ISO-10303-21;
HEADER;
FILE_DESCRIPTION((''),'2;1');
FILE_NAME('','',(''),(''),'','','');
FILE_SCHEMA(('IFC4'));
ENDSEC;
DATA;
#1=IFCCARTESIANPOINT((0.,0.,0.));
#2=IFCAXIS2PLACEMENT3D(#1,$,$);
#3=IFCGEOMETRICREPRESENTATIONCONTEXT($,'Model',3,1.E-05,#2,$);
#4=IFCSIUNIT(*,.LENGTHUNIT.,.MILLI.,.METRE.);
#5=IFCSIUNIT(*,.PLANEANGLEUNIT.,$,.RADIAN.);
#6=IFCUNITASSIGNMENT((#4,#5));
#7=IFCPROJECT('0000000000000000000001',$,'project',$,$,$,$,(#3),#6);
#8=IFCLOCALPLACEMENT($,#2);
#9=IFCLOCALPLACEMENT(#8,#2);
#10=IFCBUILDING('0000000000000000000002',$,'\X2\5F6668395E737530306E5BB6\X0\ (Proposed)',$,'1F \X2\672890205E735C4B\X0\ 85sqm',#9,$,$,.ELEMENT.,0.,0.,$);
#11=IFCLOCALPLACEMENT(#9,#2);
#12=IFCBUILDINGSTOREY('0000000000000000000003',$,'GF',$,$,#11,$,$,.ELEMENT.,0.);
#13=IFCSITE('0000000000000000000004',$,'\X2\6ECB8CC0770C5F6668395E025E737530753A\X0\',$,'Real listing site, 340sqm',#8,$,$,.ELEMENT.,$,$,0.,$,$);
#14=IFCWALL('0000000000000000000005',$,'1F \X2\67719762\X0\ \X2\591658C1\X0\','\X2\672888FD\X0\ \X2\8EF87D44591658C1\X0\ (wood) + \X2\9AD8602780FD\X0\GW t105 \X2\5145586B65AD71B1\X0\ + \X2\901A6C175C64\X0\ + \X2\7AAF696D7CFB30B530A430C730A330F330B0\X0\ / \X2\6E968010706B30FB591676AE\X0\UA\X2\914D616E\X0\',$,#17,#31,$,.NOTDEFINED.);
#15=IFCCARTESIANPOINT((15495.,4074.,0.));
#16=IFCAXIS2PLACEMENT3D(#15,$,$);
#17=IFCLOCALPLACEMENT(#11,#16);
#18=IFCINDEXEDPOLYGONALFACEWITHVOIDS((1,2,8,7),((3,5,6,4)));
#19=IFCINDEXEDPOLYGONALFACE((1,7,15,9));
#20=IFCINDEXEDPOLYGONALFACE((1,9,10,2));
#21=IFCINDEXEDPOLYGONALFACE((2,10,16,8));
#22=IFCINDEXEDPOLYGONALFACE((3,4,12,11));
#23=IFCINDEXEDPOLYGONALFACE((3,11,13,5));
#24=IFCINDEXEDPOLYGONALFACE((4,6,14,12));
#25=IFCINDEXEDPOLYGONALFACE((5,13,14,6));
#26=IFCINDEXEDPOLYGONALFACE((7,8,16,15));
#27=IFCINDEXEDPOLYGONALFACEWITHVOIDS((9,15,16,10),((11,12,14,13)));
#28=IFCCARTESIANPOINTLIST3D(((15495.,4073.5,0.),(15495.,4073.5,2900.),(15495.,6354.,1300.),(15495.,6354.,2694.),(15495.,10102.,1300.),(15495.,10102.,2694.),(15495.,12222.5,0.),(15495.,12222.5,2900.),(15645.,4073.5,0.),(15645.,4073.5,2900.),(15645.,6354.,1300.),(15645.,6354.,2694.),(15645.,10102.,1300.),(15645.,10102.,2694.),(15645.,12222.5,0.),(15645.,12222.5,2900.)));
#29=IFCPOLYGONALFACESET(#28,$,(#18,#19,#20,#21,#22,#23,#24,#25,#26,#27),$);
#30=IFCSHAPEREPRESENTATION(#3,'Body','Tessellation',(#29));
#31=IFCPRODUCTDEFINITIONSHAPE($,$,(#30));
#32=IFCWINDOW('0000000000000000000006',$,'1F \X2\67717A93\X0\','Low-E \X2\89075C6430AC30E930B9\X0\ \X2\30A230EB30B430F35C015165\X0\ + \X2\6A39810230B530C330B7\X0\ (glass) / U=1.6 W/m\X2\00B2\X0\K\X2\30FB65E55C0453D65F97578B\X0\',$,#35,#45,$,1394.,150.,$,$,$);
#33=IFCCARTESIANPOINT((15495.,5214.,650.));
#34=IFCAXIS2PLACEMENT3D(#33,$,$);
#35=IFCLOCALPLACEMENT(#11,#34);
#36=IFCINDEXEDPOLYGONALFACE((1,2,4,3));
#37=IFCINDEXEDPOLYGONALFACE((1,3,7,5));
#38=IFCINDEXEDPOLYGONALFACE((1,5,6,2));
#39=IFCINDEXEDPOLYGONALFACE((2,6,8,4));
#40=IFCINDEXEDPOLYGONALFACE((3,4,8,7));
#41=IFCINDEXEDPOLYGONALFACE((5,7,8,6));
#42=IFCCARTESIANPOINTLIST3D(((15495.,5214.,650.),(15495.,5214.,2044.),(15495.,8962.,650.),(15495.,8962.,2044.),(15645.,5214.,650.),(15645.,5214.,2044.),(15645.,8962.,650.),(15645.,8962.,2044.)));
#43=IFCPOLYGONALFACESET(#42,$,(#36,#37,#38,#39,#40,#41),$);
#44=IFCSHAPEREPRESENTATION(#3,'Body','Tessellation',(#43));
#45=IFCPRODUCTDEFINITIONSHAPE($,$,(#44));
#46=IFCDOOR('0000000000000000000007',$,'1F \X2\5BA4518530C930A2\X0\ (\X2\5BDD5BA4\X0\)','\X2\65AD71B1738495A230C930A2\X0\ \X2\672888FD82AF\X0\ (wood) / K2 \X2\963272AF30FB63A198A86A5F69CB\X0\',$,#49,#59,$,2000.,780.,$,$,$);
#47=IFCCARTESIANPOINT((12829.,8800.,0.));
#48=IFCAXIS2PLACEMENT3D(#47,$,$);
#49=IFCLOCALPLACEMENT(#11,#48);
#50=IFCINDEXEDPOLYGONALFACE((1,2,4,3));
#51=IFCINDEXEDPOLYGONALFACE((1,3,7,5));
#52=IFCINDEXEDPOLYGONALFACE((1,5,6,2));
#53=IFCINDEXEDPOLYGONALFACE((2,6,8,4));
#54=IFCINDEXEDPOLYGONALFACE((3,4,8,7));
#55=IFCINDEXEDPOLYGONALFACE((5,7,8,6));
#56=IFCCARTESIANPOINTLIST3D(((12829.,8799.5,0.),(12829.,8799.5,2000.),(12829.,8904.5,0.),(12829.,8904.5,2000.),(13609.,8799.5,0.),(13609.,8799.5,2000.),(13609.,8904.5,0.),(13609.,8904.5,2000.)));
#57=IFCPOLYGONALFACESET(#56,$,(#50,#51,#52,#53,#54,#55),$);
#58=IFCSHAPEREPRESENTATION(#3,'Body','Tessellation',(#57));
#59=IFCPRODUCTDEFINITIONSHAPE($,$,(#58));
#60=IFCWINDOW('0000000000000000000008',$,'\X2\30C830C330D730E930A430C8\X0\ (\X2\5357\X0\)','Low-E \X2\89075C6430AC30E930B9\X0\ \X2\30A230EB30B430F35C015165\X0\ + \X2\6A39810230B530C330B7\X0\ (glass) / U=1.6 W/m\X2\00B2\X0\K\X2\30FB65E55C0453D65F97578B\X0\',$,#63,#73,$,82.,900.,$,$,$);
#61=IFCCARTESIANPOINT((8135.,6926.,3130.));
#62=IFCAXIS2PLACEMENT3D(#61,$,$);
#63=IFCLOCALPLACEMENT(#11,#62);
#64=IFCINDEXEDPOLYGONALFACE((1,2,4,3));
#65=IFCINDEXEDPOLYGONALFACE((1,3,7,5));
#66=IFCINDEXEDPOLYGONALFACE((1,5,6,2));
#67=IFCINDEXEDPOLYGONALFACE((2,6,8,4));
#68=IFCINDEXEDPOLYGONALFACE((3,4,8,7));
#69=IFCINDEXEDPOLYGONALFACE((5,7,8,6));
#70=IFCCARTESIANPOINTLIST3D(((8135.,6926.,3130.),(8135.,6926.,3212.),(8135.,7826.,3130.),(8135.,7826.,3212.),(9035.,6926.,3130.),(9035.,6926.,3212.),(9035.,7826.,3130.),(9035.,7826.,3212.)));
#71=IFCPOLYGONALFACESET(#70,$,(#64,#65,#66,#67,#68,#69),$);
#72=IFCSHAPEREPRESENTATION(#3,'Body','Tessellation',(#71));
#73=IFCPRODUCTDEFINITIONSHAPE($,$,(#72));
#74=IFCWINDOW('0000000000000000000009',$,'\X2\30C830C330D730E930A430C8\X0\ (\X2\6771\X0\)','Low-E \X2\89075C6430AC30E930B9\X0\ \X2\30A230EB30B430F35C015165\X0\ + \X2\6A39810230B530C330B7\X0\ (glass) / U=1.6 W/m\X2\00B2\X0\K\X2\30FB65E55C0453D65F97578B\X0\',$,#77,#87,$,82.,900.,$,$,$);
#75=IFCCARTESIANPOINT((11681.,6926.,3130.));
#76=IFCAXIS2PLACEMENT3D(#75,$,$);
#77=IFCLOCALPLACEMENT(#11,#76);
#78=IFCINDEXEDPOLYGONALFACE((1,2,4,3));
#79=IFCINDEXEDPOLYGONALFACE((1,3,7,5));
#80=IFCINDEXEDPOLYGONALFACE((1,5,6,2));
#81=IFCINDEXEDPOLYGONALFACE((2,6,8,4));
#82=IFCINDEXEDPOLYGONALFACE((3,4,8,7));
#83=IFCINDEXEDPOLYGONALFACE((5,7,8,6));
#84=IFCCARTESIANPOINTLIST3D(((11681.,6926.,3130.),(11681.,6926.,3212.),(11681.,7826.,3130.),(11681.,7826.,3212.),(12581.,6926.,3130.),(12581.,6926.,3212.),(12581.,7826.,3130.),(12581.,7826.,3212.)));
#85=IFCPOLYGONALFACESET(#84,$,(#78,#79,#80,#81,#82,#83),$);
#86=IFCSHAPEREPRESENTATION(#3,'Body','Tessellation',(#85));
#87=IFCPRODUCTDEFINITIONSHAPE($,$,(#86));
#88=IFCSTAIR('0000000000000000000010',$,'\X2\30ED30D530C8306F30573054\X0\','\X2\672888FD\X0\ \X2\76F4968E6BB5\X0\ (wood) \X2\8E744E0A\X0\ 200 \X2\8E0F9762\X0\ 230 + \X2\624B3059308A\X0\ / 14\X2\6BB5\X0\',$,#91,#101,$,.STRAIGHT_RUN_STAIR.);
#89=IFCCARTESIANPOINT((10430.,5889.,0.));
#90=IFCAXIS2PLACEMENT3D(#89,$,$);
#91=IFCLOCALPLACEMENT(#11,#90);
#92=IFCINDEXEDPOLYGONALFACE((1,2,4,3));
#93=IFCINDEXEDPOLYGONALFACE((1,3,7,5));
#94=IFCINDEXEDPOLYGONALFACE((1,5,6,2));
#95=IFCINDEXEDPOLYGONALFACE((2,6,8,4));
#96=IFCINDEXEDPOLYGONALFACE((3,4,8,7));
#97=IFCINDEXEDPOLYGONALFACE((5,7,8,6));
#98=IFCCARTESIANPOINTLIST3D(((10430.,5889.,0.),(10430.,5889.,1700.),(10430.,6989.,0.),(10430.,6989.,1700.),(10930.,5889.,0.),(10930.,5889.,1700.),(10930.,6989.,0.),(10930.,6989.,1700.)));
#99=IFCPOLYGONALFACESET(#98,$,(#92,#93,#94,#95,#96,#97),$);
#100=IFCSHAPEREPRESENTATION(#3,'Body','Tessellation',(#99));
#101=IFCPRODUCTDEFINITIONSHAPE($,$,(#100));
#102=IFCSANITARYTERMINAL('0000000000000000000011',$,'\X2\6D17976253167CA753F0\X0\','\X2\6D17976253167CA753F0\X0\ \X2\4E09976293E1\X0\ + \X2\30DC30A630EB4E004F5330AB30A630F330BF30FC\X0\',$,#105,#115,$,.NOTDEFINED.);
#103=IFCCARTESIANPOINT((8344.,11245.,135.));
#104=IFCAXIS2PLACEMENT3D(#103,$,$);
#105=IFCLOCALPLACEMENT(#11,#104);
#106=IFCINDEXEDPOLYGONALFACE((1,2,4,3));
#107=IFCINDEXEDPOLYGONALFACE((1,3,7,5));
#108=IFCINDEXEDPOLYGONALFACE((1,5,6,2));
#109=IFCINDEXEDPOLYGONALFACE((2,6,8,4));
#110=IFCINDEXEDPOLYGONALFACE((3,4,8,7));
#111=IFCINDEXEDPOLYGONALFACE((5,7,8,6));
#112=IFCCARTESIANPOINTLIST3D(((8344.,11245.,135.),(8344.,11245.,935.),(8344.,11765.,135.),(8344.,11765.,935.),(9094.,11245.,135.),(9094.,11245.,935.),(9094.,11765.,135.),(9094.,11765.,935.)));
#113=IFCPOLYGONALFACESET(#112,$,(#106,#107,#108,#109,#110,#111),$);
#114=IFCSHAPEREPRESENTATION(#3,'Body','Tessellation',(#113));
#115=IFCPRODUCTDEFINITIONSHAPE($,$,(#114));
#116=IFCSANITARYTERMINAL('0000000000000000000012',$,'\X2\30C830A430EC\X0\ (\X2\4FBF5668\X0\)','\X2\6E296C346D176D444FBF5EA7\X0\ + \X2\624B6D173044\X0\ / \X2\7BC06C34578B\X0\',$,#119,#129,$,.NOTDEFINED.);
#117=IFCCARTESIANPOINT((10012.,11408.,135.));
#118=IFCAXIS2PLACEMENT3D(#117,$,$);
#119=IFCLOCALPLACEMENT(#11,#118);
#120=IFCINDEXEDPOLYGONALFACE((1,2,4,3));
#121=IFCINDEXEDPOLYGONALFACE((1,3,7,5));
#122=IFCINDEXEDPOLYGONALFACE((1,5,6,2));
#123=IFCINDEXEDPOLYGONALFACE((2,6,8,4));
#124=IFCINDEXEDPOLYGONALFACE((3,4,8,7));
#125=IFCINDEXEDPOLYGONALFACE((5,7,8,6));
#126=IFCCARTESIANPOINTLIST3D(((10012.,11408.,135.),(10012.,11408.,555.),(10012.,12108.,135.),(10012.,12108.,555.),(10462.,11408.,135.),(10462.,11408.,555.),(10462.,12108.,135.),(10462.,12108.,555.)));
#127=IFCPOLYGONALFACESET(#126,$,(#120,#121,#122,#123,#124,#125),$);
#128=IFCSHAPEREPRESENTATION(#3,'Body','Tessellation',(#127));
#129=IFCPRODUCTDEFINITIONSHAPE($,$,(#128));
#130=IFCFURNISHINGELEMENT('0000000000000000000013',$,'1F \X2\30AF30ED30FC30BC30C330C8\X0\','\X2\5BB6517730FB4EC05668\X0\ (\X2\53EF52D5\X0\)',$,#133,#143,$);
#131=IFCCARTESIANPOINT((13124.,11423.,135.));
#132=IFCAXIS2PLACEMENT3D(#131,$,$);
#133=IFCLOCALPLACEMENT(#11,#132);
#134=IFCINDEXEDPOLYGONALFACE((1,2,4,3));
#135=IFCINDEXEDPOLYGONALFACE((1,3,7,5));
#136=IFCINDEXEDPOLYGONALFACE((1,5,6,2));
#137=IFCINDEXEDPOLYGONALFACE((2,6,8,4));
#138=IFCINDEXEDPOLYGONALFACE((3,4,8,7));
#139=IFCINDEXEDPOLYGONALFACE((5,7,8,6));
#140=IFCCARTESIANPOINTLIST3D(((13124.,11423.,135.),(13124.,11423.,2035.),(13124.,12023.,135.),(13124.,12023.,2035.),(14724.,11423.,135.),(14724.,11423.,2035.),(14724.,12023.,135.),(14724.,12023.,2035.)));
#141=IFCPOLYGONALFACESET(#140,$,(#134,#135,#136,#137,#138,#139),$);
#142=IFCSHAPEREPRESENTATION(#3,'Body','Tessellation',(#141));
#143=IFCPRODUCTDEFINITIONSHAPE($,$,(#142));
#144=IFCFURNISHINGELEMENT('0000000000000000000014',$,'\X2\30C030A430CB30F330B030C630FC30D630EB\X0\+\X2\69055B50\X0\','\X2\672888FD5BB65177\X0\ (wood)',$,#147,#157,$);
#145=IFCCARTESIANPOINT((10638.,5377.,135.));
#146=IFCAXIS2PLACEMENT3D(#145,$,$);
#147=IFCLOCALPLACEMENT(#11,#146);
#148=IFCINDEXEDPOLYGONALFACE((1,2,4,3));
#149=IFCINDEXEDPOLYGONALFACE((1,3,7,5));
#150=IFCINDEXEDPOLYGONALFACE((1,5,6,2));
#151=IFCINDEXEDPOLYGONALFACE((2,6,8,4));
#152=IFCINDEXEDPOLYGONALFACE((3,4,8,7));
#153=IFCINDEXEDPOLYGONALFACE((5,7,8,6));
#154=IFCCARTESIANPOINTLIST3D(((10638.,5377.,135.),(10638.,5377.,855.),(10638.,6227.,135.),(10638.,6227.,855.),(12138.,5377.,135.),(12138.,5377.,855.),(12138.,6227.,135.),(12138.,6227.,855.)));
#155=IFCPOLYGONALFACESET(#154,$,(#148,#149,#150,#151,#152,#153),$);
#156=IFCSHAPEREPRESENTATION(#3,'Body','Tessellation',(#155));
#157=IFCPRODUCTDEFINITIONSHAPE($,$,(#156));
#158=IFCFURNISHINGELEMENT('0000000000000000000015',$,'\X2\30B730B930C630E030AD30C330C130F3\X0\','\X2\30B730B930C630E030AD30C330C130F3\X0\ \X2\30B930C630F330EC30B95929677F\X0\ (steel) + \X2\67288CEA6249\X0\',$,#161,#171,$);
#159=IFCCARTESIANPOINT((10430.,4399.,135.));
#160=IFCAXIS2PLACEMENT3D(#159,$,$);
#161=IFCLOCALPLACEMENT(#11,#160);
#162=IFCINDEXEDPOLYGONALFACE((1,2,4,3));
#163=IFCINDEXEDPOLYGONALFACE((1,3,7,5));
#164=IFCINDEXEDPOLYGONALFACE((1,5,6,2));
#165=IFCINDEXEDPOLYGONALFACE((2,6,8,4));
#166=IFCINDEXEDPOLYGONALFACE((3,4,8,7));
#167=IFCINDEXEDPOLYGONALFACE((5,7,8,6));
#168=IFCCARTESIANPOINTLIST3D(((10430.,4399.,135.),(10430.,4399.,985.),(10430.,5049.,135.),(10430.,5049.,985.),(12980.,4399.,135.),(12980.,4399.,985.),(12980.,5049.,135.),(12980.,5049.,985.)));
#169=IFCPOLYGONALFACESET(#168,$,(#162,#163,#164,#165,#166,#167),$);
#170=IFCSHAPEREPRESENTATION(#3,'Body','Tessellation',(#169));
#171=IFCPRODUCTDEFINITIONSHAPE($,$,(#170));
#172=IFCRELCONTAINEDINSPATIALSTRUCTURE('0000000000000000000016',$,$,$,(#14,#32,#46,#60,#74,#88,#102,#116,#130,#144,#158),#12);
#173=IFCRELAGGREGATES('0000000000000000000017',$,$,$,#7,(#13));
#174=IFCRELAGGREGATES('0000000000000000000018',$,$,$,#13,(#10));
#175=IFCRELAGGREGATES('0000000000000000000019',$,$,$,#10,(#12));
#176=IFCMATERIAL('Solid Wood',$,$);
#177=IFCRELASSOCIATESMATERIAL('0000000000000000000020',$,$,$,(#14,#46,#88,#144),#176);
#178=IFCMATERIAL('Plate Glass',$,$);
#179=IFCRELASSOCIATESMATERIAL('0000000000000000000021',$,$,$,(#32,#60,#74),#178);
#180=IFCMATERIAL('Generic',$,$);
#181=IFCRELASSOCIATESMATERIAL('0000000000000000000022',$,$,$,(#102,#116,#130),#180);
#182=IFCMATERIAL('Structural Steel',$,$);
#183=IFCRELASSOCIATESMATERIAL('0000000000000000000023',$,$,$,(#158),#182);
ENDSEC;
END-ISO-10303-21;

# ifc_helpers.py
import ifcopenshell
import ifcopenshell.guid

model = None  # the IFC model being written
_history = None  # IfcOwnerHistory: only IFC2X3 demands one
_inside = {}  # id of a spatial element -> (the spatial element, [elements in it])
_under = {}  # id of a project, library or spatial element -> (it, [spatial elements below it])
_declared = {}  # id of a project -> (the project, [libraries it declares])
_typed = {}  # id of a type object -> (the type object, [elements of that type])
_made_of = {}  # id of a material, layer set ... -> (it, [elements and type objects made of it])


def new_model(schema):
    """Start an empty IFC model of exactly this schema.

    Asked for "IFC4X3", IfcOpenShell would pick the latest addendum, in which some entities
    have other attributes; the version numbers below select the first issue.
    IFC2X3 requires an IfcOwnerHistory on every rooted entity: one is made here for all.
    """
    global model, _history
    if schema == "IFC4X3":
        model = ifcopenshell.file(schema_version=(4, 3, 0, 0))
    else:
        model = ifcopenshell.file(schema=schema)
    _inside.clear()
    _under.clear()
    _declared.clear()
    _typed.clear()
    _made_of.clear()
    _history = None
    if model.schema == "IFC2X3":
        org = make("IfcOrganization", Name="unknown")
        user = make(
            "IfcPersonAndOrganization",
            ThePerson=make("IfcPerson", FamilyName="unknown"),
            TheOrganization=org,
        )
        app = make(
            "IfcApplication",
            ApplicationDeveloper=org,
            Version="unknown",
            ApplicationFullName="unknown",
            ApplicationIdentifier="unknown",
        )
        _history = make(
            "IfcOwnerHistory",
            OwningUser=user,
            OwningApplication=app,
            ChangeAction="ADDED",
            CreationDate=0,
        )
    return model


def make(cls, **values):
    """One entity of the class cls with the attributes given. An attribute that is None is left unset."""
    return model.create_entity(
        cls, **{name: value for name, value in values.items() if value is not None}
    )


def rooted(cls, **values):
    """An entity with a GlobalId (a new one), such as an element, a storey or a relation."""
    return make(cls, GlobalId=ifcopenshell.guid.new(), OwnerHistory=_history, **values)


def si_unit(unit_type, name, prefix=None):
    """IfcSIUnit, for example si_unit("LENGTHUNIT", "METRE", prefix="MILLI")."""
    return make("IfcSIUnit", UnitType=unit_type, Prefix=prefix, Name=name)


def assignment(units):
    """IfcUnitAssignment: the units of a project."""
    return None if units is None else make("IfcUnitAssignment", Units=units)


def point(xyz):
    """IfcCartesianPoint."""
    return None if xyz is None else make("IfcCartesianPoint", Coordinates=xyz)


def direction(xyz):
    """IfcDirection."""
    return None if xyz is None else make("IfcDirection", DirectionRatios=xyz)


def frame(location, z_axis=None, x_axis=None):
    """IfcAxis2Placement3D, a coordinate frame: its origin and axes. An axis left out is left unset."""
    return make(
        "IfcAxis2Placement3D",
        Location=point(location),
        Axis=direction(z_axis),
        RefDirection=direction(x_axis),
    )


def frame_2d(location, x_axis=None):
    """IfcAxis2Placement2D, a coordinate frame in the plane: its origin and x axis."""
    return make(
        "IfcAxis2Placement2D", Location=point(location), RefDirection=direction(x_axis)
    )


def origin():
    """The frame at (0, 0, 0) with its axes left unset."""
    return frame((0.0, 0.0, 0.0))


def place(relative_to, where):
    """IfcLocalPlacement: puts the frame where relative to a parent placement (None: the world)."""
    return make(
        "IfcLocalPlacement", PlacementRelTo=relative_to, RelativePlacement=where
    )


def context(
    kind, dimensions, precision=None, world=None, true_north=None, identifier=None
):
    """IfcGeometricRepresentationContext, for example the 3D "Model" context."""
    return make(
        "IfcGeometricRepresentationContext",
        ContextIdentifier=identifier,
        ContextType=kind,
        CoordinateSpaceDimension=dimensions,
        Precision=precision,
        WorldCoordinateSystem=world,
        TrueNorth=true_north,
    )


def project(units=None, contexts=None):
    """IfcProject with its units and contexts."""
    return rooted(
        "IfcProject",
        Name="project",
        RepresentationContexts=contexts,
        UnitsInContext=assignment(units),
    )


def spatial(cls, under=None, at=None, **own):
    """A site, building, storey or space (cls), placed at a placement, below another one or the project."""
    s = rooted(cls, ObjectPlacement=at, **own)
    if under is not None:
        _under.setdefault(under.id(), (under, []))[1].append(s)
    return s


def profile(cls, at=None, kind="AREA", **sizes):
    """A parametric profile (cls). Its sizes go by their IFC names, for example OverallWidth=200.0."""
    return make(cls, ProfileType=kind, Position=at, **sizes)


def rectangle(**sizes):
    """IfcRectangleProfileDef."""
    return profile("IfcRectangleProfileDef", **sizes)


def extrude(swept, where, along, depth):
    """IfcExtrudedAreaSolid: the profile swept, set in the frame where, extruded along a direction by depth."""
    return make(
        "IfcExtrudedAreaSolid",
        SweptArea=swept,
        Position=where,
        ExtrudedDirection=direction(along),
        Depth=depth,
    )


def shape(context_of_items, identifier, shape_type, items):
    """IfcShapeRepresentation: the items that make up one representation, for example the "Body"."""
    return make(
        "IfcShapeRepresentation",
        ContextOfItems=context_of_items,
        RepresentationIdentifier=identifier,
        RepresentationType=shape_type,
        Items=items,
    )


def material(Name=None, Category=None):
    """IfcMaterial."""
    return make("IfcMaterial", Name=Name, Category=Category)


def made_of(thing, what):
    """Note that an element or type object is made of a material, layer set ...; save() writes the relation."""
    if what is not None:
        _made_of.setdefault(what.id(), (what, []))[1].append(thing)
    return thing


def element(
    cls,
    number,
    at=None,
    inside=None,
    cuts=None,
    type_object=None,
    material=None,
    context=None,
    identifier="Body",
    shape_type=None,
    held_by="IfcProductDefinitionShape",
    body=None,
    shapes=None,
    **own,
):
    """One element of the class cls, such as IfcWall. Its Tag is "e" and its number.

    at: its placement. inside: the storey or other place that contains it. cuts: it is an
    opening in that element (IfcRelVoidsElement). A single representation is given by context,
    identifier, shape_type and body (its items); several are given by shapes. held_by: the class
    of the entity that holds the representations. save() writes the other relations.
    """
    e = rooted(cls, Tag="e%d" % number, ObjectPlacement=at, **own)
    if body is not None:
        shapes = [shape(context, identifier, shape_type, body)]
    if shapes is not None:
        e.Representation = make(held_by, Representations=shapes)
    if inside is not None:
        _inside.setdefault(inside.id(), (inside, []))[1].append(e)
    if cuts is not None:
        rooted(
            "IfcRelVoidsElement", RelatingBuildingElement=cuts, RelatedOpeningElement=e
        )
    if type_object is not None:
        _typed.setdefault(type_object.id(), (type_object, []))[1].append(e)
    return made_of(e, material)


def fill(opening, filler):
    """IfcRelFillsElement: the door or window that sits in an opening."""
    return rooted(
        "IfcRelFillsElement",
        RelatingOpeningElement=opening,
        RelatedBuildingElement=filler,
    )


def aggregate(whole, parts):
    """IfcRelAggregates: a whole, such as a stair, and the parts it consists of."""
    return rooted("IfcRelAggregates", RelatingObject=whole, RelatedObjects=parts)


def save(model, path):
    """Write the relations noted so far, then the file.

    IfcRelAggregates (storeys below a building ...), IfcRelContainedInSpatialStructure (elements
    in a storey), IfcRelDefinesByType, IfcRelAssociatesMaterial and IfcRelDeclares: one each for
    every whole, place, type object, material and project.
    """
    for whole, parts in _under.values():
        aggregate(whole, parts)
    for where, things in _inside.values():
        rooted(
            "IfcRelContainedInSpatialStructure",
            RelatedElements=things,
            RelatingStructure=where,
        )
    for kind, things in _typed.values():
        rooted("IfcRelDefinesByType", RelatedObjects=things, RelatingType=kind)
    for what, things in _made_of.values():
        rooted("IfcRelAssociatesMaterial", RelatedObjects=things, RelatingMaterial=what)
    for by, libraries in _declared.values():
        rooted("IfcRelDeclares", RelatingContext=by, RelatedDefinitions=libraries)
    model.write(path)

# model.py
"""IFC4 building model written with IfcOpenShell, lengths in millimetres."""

from ifc_helpers import new_model, si_unit, frame, frame_2d, origin, place, context, project, spatial, rectangle, extrude, material, element, fill, save


model = new_model("IFC4")

# Units and contexts
model_context = context("Model", 3, precision=1e-05, world=origin())
ifc_project = project(units=[si_unit("LENGTHUNIT", "METRE", prefix="MILLI"), si_unit("PLANEANGLEUNIT", "RADIAN")], contexts=[model_context])

# Site, building, storey
site_placement = place(None, origin())
site = spatial("IfcSite", under=ifc_project, at=site_placement, Name="滋賀県彦根市平田町", ObjectType="Real listing site, 340sqm", CompositionType="ELEMENT", RefElevation=0.0)
building_placement = place(site_placement, origin())
building = spatial("IfcBuilding", under=site, at=building_placement, Name="彦根平田の家 (Proposed)", ObjectType="1F 木造平屋 85sqm", CompositionType="ELEMENT", ElevationOfRefHeight=0.0, ElevationOfTerrain=0.0)
storey_placement = place(building_placement, origin())
storey = spatial("IfcBuildingStorey", under=building, at=storey_placement, Name="GF", CompositionType="ELEMENT", Elevation=0.0)

# Wall, opening, window
ifc_material_1 = material(Name="Solid Wood")
wall_1_placement = place(storey_placement, frame((15495.0, 4074.0, 0.0)))
wall_1 = element("IfcWall", 1, at=wall_1_placement, inside=storey, material=ifc_material_1, Name="1F 東面 外壁", Description="木製 軸組外壁 (wood) + 高性能GW t105 充填断熱 + 通気層 + 窯業系サイディング / 準耐火・外皮UA配慮", PredefinedType="NOTDEFINED", context=model_context, shape_type="SweptSolid", body=[
    extrude(rectangle(XDim=150.0, YDim=8149.0, at=frame_2d((75.0, 4074.0))), frame((15495.0, 4074.0, 0.0)), (0.0, 0.0, 1.0), 2900.0),
])
opening_placement = place(storey_placement, frame((15495.0, 5214.0, 650.0)))
opening = element("IfcOpeningElement", 2, at=opening_placement, cuts=wall_1, PredefinedType="NOTDEFINED", context=model_context, shape_type="SweptSolid", body=[
    extrude(rectangle(XDim=150.0, YDim=3748.0, at=frame_2d((75.0, 1874.0))), frame((15495.0, 5214.0, 650.0)), (0.0, 0.0, 1.0), 1394.0),
])
ifc_material_2 = material(Name="Plate Glass")
window_1_placement = place(storey_placement, frame((15495.0, 5214.0, 650.0)))
window_1 = element("IfcWindow", 3, at=window_1_placement, inside=storey, material=ifc_material_2, Name="1F 東窓", Description="Low-E 複層ガラス アルゴン封入 + 樹脂サッシ (glass) / U=1.6 W/m²K・日射取得型", OverallHeight=1394.0, OverallWidth=150.0, context=model_context, shape_type="SweptSolid", body=[
    extrude(rectangle(XDim=150.0, YDim=3748.0, at=frame_2d((75.0, 1874.0))), frame((15495.0, 5214.0, 650.0)), (0.0, 0.0, 1.0), 1394.0),
])
fill(opening, window_1)

# Door
door_placement = place(storey_placement, frame((12829.0, 8800.0, 0.0)))
element("IfcDoor", 4, at=door_placement, inside=storey, material=ifc_material_1, Name="1F 室内ドア (寝室)", Description="断熱玄関ドア 木製芯 (wood) / K2 防犯・採風機構", OverallHeight=2000.0, OverallWidth=780.0, context=model_context, shape_type="SweptSolid", body=[
    extrude(rectangle(XDim=780.0, YDim=105.0, at=frame_2d((390.0, 52.0))), frame((12829.0, 8800.0, 0.0)), (0.0, 0.0, 1.0), 2000.0),
])

# Windows
window_2_placement = place(storey_placement, frame((8135.0, 6926.0, 3130.0)))
element("IfcWindow", 5, at=window_2_placement, inside=storey, material=ifc_material_2, Name="トップライト (南)", Description="Low-E 複層ガラス アルゴン封入 + 樹脂サッシ (glass) / U=1.6 W/m²K・日射取得型", OverallHeight=82.0, OverallWidth=900.0, context=model_context, shape_type="SweptSolid", body=[
    extrude(rectangle(XDim=900.0, YDim=900.0, at=frame_2d((450.0, 450.0))), frame((8135.0, 6926.0, 3130.0)), (0.0, 0.0, 1.0), 82.0),
])
window_3_placement = place(storey_placement, frame((11681.0, 6926.0, 3130.0)))
element("IfcWindow", 6, at=window_3_placement, inside=storey, material=ifc_material_2, Name="トップライト (東)", Description="Low-E 複層ガラス アルゴン封入 + 樹脂サッシ (glass) / U=1.6 W/m²K・日射取得型", OverallHeight=82.0, OverallWidth=900.0, context=model_context, shape_type="SweptSolid", body=[
    extrude(rectangle(XDim=900.0, YDim=900.0, at=frame_2d((450.0, 450.0))), frame((11681.0, 6926.0, 3130.0)), (0.0, 0.0, 1.0), 82.0),
])

# Stair
stair_placement = place(storey_placement, frame((10430.0, 5889.0, 0.0)))
element("IfcStair", 7, at=stair_placement, inside=storey, material=ifc_material_1, Name="ロフトはしご", Description="木製 直階段 (wood) 蹴上 200 踏面 230 + 手すり / 14段", PredefinedType="STRAIGHT_RUN_STAIR", context=model_context, shape_type="SweptSolid", body=[
    extrude(rectangle(XDim=500.0, YDim=1100.0, at=frame_2d((250.0, 550.0))), frame((10430.0, 5889.0, 0.0)), (0.0, 0.0, 1.0), 1700.0),
])

# Sanitary terminals
ifc_material_3 = material(Name="Generic")
sanitary_terminal_1_placement = place(storey_placement, frame((8344.0, 11245.0, 135.0)))
element("IfcSanitaryTerminal", 8, at=sanitary_terminal_1_placement, inside=storey, material=ifc_material_3, Name="洗面化粧台", Description="洗面化粧台 三面鏡 + ボウル一体カウンター", PredefinedType="NOTDEFINED", context=model_context, shape_type="SweptSolid", body=[
    extrude(rectangle(XDim=750.0, YDim=520.0, at=frame_2d((375.0, 260.0))), frame((8344.0, 11245.0, 135.0)), (0.0, 0.0, 1.0), 800.0),
])
sanitary_terminal_2_placement = place(storey_placement, frame((10012.0, 11408.0, 135.0)))
element("IfcSanitaryTerminal", 9, at=sanitary_terminal_2_placement, inside=storey, material=ifc_material_3, Name="トイレ (便器)", Description="温水洗浄便座 + 手洗い / 節水型", PredefinedType="NOTDEFINED", context=model_context, shape_type="SweptSolid", body=[
    extrude(rectangle(XDim=450.0, YDim=700.0, at=frame_2d((225.0, 350.0))), frame((10012.0, 11408.0, 135.0)), (0.0, 0.0, 1.0), 420.0),
])

# Furnishing elements
furnishing_1_placement = place(storey_placement, frame((13124.0, 11423.0, 135.0)))
element("IfcFurnishingElement", 10, at=furnishing_1_placement, inside=storey, material=ifc_material_3, Name="1F クローゼット", Description="家具・什器 (可動)", context=model_context, shape_type="SweptSolid", body=[
    extrude(rectangle(XDim=1600.0, YDim=600.0, at=frame_2d((800.0, 300.0))), frame((13124.0, 11423.0, 135.0)), (0.0, 0.0, 1.0), 1900.0),
])
furnishing_2_placement = place(storey_placement, frame((10638.0, 5377.0, 135.0)))
element("IfcFurnishingElement", 11, at=furnishing_2_placement, inside=storey, material=ifc_material_1, Name="ダイニングテーブル+椅子", Description="木製家具 (wood)", context=model_context, shape_type="SweptSolid", body=[
    extrude(rectangle(XDim=1500.0, YDim=850.0, at=frame_2d((750.0, 425.0))), frame((10638.0, 5377.0, 135.0)), (0.0, 0.0, 1.0), 720.0),
])
ifc_material_4 = material(Name="Structural Steel")
furnishing_3_placement = place(storey_placement, frame((10430.0, 4399.0, 135.0)))
element("IfcFurnishingElement", 12, at=furnishing_3_placement, inside=storey, material=ifc_material_4, Name="システムキッチン", Description="システムキッチン ステンレス天板 (steel) + 木質扉", context=model_context, shape_type="SweptSolid", body=[
    extrude(rectangle(XDim=2550.0, YDim=650.0, at=frame_2d((1275.0, 325.0))), frame((10430.0, 4399.0, 135.0)), (0.0, 0.0, 1.0), 850.0),
])

save(model, "model.ifc")
